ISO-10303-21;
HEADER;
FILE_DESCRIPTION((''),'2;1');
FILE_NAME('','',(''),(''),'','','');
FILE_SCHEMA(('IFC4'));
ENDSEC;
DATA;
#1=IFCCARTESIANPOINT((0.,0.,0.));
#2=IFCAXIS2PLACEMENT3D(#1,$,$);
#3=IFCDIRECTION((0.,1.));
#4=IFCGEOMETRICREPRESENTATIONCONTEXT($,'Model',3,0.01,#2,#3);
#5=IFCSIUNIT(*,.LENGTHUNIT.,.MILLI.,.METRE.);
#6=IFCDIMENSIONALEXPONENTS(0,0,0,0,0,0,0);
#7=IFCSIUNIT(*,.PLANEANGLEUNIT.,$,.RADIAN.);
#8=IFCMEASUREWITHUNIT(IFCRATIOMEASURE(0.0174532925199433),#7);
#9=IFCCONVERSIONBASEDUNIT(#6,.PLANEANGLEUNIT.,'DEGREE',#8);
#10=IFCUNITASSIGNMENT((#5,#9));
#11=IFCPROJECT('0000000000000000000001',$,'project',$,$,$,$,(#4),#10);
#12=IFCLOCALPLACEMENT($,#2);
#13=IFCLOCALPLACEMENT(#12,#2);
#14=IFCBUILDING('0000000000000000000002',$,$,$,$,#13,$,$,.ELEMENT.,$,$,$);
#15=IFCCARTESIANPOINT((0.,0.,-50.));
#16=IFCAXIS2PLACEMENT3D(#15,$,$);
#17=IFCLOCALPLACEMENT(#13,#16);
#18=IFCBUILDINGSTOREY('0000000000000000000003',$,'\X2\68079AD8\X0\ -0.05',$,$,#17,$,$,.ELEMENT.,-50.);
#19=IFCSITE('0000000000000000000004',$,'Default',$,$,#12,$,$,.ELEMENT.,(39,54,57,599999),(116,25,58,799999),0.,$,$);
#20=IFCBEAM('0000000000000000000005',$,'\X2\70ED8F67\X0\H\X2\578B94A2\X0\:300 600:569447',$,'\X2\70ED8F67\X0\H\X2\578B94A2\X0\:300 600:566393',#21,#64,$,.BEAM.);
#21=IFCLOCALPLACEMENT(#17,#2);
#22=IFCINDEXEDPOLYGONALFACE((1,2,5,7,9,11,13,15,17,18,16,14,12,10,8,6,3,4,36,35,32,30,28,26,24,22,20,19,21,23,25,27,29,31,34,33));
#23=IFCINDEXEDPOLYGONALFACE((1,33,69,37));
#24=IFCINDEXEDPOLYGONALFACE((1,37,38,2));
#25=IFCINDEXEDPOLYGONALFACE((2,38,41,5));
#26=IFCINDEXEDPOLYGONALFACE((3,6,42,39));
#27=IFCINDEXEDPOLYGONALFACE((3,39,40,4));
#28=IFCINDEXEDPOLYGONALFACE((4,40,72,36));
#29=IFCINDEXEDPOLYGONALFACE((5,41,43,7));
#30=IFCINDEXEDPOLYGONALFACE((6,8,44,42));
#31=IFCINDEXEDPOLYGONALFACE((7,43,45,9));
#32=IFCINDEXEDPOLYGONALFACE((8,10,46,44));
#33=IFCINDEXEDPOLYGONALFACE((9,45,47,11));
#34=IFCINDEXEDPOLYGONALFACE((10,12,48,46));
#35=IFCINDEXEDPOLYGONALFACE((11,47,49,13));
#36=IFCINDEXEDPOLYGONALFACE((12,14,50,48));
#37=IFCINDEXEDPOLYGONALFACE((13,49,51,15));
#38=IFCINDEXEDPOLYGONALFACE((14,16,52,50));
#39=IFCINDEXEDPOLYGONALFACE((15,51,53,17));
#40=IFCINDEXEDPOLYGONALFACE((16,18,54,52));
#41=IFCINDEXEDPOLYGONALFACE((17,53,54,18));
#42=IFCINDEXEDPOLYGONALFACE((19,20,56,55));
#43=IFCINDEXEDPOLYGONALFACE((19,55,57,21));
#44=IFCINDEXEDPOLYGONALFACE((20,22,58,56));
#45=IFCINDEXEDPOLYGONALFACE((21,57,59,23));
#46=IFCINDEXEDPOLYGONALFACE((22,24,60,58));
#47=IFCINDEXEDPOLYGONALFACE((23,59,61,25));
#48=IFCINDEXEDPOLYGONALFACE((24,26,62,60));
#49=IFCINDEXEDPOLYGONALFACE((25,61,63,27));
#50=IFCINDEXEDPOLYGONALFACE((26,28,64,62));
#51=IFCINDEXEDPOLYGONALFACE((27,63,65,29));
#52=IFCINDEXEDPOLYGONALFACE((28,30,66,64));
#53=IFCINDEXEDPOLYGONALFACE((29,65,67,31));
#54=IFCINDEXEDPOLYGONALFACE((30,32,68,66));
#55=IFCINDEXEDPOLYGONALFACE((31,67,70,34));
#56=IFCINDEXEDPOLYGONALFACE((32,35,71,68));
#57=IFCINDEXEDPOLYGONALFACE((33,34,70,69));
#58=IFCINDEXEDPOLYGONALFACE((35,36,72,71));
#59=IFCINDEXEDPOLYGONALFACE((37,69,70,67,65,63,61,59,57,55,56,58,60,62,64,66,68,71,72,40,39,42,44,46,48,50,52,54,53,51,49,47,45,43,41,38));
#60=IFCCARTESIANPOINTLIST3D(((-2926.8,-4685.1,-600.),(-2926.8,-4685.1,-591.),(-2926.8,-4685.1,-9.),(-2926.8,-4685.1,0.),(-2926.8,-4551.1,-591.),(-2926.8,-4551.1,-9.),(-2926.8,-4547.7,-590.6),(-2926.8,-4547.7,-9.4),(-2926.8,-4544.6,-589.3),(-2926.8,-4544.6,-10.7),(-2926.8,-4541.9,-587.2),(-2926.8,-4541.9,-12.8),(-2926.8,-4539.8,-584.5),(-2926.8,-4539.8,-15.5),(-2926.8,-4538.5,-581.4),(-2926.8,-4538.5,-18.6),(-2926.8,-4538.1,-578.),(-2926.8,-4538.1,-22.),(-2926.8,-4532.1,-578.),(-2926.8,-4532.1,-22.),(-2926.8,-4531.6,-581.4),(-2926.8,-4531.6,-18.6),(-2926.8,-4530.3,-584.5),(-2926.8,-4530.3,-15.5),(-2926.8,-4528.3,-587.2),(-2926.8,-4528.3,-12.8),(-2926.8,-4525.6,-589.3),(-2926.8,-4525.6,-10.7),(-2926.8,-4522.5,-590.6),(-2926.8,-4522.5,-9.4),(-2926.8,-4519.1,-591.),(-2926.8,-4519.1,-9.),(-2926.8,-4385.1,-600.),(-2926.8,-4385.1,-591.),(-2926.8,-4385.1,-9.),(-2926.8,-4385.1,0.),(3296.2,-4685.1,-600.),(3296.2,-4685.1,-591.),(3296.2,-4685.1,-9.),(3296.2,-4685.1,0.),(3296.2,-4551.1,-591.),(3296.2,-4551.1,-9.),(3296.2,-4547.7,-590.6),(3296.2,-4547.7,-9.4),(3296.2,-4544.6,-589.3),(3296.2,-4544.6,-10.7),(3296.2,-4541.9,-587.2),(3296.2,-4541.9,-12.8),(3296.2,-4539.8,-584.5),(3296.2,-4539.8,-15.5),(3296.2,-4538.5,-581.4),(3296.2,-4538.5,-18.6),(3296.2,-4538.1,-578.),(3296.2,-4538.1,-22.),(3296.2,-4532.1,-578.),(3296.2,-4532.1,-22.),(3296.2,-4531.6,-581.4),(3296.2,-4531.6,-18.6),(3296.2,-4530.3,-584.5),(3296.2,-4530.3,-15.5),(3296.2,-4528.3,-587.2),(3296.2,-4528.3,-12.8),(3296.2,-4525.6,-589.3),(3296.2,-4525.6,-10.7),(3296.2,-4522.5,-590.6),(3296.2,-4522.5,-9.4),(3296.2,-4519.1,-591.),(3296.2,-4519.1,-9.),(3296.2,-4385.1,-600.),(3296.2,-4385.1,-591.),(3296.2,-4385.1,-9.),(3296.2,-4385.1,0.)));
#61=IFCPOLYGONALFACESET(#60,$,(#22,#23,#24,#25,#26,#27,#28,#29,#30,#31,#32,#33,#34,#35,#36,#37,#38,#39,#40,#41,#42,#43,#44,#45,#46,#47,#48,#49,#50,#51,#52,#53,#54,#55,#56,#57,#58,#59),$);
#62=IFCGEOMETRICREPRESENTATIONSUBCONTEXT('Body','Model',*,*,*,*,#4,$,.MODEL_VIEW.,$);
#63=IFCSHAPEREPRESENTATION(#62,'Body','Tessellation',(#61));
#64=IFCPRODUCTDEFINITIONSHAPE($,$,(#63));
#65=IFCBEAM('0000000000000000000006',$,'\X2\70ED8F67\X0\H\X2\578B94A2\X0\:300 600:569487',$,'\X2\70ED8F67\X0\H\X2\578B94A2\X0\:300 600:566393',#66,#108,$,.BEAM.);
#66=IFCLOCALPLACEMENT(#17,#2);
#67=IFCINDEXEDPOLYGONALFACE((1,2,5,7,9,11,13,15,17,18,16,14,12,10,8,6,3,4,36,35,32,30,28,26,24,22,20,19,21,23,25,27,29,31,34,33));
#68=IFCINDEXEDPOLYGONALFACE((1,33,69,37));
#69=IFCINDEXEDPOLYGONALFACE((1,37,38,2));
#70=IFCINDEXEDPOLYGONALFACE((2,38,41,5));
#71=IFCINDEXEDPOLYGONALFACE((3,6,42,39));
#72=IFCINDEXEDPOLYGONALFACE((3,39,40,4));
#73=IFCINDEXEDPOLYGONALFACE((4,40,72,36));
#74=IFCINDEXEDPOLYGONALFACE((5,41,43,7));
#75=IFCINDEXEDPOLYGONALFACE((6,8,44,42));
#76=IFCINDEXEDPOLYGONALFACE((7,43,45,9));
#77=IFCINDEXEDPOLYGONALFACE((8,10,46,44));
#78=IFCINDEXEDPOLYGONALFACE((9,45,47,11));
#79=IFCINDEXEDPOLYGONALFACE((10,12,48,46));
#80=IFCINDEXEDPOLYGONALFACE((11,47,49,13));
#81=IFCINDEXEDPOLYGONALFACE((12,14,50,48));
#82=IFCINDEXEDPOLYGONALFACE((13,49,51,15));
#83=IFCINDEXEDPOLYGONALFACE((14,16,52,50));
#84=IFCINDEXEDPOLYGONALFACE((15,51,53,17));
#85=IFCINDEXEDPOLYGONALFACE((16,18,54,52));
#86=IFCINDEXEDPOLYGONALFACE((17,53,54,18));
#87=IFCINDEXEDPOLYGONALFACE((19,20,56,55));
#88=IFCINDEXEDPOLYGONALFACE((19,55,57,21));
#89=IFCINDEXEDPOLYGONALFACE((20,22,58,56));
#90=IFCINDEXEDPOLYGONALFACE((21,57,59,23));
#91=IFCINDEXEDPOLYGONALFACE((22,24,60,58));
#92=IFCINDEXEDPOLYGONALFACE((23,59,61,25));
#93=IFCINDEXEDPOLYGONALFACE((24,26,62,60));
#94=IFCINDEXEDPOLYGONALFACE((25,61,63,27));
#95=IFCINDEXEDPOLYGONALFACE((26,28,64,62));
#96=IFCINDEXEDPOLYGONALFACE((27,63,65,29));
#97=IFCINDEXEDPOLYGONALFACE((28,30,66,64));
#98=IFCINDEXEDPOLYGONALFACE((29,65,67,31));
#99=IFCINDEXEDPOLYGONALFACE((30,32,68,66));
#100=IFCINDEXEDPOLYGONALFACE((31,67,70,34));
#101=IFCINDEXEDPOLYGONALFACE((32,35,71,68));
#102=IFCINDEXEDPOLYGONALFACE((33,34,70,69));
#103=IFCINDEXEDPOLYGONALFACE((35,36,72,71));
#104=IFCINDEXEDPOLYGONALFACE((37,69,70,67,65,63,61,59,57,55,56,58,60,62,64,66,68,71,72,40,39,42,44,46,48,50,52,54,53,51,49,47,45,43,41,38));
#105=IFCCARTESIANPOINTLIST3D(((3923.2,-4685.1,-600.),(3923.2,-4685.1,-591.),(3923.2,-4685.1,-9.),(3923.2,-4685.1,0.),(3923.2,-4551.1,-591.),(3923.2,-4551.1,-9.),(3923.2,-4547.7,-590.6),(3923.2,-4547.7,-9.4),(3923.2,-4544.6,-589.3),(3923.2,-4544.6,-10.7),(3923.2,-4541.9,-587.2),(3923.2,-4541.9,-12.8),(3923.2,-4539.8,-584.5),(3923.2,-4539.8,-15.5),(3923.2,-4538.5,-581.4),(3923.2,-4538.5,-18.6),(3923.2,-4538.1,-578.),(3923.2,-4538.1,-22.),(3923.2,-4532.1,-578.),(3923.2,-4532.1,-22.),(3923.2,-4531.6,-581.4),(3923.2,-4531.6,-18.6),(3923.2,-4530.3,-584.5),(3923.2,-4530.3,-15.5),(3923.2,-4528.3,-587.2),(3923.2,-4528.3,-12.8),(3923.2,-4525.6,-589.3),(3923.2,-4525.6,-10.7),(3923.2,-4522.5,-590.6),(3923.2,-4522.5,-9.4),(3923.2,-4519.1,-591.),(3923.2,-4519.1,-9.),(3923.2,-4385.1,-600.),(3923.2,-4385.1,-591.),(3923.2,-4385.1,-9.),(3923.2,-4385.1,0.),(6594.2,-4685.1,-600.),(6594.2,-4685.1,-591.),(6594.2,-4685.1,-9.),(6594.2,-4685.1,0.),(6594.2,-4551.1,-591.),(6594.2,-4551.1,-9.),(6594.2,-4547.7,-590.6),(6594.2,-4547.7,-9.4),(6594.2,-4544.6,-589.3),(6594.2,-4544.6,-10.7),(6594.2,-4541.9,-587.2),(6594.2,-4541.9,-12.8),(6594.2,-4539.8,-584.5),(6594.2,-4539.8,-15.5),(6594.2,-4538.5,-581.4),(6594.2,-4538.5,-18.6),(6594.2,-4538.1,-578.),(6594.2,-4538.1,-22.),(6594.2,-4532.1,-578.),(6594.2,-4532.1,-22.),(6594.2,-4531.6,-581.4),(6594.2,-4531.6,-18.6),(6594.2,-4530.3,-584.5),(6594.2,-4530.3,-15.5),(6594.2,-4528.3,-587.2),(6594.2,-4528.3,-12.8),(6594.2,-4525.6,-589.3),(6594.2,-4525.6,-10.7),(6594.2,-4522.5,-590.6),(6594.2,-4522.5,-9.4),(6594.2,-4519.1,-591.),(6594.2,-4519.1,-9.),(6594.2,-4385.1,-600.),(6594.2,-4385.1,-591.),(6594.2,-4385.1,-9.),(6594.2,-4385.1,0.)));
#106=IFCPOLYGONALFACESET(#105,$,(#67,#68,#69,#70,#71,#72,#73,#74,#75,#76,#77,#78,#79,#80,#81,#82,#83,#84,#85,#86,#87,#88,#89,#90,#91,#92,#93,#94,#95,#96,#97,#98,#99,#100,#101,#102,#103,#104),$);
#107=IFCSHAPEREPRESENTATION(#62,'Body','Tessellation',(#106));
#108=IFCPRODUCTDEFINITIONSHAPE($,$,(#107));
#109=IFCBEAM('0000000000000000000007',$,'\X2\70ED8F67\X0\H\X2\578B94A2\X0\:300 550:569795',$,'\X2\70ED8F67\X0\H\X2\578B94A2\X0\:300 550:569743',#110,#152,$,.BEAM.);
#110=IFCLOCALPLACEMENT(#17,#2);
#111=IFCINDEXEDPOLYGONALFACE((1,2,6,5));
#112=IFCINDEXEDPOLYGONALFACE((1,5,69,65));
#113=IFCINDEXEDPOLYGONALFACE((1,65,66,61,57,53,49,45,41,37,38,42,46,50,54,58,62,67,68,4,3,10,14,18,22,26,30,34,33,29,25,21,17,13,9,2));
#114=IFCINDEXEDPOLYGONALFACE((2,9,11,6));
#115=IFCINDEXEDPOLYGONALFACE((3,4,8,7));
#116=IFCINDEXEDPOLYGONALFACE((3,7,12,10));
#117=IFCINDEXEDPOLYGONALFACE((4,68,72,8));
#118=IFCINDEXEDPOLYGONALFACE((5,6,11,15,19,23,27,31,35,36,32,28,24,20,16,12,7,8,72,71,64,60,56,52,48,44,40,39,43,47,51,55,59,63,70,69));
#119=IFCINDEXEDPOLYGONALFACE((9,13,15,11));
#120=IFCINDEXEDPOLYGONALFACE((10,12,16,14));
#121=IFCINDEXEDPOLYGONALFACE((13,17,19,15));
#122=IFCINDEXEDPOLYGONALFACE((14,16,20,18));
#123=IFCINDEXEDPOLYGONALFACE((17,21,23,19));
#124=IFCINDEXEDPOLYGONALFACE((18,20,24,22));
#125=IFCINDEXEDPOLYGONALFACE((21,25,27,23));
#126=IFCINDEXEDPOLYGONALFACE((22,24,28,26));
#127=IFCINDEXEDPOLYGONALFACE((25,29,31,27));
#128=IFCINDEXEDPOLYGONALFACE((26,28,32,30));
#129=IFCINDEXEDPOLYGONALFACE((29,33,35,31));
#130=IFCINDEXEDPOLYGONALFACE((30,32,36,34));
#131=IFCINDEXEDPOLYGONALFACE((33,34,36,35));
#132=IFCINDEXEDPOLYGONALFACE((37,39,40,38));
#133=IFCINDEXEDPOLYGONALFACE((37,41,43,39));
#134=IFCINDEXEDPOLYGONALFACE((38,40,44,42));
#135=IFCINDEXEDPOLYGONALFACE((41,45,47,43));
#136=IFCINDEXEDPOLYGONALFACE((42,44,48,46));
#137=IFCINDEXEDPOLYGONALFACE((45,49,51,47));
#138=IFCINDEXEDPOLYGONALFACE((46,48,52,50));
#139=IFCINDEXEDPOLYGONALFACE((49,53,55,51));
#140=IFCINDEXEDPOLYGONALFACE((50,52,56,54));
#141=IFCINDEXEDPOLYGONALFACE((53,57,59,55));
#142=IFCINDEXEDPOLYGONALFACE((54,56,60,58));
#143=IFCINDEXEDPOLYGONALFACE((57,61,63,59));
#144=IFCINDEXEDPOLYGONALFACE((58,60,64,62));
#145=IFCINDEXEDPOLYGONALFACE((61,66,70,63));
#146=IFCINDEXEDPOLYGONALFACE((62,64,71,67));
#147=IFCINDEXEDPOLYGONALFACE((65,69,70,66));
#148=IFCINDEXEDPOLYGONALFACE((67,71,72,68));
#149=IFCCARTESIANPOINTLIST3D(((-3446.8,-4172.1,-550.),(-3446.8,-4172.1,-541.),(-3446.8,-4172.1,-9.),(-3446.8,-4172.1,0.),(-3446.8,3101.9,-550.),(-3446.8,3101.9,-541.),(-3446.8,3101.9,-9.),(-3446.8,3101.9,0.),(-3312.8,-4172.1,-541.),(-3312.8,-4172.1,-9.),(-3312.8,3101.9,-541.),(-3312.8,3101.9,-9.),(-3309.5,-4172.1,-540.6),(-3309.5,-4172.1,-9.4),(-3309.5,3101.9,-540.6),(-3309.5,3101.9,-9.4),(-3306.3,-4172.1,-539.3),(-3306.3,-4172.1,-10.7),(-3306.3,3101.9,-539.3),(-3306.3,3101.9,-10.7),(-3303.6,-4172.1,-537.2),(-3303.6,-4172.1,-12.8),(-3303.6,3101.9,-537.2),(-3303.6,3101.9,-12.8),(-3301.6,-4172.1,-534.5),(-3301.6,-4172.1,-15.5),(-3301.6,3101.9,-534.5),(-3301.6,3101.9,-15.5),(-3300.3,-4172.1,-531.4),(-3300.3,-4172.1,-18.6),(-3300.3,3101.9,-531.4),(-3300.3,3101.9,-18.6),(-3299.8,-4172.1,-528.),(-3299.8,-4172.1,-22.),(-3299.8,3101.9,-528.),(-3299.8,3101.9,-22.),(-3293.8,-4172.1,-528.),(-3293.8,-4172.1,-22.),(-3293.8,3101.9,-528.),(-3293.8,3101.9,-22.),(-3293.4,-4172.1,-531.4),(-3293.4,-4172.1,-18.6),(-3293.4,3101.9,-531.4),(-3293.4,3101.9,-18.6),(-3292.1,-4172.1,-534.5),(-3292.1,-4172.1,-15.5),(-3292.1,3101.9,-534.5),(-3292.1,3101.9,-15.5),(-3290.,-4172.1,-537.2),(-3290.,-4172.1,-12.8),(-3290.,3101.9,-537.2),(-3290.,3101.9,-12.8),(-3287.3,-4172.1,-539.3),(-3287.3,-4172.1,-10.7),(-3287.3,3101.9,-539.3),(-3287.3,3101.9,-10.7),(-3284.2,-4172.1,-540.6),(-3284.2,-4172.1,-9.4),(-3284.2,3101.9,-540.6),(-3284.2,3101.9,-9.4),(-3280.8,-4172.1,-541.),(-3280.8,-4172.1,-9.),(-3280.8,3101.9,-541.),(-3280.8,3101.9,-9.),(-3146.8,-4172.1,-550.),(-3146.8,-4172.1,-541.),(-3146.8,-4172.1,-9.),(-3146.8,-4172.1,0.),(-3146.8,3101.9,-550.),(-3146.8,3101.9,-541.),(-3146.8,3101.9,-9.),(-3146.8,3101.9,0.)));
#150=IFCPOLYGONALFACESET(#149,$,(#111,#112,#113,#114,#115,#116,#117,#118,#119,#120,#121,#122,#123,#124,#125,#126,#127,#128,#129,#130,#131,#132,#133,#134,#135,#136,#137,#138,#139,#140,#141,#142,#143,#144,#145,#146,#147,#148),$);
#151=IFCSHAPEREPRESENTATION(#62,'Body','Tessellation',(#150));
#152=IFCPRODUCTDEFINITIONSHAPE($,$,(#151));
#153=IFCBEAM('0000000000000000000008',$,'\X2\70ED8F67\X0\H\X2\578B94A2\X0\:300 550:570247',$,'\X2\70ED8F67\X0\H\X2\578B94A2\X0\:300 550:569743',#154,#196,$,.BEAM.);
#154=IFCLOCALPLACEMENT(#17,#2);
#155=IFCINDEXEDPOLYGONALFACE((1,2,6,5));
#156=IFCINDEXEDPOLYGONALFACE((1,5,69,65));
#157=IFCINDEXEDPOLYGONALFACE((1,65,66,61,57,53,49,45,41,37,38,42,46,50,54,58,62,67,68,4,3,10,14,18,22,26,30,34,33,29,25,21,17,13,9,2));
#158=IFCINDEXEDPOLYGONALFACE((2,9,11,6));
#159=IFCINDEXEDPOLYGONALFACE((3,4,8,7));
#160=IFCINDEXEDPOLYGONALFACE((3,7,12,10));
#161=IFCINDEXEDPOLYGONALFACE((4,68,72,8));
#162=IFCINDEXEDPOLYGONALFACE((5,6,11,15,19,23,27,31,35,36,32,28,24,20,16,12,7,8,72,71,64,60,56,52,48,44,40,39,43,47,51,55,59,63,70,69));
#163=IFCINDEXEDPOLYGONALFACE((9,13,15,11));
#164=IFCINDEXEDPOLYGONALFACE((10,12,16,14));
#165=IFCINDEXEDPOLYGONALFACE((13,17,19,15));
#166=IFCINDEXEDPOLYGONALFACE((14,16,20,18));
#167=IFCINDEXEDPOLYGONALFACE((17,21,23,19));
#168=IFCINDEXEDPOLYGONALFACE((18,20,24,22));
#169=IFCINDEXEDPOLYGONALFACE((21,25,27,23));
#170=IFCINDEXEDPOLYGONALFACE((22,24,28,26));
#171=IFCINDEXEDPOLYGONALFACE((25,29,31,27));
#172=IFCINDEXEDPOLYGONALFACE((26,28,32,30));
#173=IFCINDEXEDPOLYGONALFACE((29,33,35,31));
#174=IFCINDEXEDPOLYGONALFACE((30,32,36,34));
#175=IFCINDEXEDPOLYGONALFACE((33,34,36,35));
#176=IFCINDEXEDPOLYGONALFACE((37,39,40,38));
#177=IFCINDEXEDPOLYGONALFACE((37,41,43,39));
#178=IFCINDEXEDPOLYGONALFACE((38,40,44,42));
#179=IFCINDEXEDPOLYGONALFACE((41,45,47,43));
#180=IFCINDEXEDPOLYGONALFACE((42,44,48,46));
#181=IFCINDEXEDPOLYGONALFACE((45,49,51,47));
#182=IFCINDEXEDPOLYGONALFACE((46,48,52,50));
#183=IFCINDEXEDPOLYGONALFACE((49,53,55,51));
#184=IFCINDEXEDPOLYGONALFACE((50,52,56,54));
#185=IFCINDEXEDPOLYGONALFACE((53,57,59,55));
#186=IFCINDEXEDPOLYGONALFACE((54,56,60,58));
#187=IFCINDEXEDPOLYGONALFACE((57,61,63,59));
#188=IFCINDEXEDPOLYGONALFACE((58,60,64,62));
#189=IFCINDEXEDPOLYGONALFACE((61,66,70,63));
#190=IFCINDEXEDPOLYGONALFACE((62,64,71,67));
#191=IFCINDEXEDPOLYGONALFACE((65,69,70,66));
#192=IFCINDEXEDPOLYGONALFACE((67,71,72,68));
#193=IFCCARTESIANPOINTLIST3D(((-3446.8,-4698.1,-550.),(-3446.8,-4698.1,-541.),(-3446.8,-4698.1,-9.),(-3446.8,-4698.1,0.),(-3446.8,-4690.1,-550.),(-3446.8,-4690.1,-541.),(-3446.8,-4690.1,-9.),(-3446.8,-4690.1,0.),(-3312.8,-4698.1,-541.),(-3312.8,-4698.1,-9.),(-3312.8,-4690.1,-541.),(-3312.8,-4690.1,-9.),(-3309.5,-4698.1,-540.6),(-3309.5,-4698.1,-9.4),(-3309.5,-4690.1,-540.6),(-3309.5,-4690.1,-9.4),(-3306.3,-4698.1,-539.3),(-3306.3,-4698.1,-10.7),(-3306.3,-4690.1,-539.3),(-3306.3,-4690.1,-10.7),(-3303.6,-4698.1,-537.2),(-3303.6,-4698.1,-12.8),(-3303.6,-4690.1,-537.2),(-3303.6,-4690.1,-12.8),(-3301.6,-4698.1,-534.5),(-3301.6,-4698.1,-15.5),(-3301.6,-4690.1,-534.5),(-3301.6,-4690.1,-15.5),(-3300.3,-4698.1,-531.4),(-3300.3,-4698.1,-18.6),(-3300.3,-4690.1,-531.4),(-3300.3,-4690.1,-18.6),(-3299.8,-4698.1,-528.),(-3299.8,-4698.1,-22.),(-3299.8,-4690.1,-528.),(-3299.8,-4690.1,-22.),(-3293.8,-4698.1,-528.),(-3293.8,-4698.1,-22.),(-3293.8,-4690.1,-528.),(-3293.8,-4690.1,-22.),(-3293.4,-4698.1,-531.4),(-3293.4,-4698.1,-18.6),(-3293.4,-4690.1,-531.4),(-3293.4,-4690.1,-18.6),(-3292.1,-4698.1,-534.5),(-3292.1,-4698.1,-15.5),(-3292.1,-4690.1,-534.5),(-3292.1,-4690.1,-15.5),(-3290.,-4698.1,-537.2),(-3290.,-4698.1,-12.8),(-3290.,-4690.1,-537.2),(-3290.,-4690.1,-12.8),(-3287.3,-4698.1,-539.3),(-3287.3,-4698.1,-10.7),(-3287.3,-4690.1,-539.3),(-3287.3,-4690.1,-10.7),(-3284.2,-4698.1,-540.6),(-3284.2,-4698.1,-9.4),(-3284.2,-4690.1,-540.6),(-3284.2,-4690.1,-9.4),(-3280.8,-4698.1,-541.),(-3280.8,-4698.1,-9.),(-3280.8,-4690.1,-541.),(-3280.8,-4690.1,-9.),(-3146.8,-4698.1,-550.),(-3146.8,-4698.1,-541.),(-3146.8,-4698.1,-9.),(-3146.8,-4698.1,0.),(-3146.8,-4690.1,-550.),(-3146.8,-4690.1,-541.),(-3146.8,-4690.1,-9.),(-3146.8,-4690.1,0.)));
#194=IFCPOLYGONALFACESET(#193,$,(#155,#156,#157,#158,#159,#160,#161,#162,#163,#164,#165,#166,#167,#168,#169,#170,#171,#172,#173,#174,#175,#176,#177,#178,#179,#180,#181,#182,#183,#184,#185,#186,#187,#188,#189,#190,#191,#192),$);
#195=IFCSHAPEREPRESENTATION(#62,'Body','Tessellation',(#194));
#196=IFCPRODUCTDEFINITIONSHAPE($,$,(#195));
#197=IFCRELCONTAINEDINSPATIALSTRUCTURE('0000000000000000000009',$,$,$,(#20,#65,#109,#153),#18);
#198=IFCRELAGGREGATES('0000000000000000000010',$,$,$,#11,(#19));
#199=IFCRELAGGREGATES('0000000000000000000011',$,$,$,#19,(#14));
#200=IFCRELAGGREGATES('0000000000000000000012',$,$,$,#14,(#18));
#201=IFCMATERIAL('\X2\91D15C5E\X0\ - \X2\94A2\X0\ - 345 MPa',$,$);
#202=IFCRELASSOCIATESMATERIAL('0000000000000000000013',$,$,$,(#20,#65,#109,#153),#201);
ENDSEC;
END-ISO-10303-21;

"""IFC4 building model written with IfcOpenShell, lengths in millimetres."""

from ifc_helpers import new_model, entity, si_unit, converted_unit, direction, frame, frame_2d, origin, place, context, subcontext, project, spatial, i_section, extrude, material, element, save


model = new_model("IFC4")

# Units and contexts
model_context = context("Model", 3, precision=0.01, world=origin(), true_north=direction((0.0, 1.0)))
body_context = subcontext(model_context, "Body", "Model", "MODEL_VIEW")
ifc_project = project(units=[si_unit("LENGTHUNIT", "METRE", prefix="MILLI"), converted_unit("PLANEANGLEUNIT", "DEGREE", entity("IfcRatioMeasure", 0.0174532925199433), si_unit("PLANEANGLEUNIT", "RADIAN"), dimensions=[0, 0, 0, 0, 0, 0, 0])], contexts=[model_context])

# Site, building, storey
site_placement = place(None, origin())
site = spatial("IfcSite", under=ifc_project, at=site_placement, Name="Default", CompositionType="ELEMENT", RefLatitude=(39, 54, 57, 599999), RefLongitude=(116, 25, 58, 799999), RefElevation=0.0)
building_placement = place(site_placement, origin())
building = spatial("IfcBuilding", under=site, at=building_placement, CompositionType="ELEMENT")
storey_placement = place(building_placement, frame((0.0, 0.0, -50.0)))
storey = spatial("IfcBuildingStorey", under=building, at=storey_placement, Name="标高 -0.05", CompositionType="ELEMENT", Elevation=-50.0)

# Beams
ifc_material_1 = material(Name="金属 - 钢 - 345 MPa")
beam_1_placement = place(storey_placement, frame((-2946.8, -4535.1, 0.0)))
element("IfcBeam", 1, at=beam_1_placement, inside=storey, material=ifc_material_1, Name="热轧H型钢:300 600:569447", ObjectType="热轧H型钢:300 600:566393", PredefinedType="BEAM", context=body_context, shape_type="SweptSolid", body=[
    extrude(i_section(OverallWidth=300.0, OverallDepth=600.0, WebThickness=6.0, FlangeThickness=9.0, FilletRadius=13.0, at=frame_2d((0.0, 0.0), x_axis=(0.0, 1.0))), frame((20.0, 0.0, -300.0), z_axis=(1.0, 0.0, 0.0), x_axis=(0.0, 0.0, -1.0)), (0.0, 0.0, 1.0), 6223.0),
])
beam_2_placement = place(storey_placement, frame((3903.2, -4535.1, 0.0)))
element("IfcBeam", 2, at=beam_2_placement, inside=storey, material=ifc_material_1, Name="热轧H型钢:300 600:569487", ObjectType="热轧H型钢:300 600:566393", PredefinedType="BEAM", context=body_context, shape_type="SweptSolid", body=[
    extrude(i_section(OverallWidth=300.0, OverallDepth=600.0, WebThickness=6.0, FlangeThickness=9.0, FilletRadius=13.0, at=frame_2d((0.0, 0.0), x_axis=(0.0, 1.0))), frame((20.0, 0.0, -300.0), z_axis=(1.0, 0.0, 0.0), x_axis=(0.0, 0.0, -1.0)), (0.0, 0.0, 1.0), 2671.0),
])
beam_3_placement = place(storey_placement, frame((-3296.8, -4190.1, 0.0), z_axis=(0.0, 0.0, 1.0), x_axis=(0.0, 1.0, 0.0)))
element("IfcBeam", 3, at=beam_3_placement, inside=storey, material=ifc_material_1, Name="热轧H型钢:300 550:569795", ObjectType="热轧H型钢:300 550:569743", PredefinedType="BEAM", context=body_context, shape_type="SweptSolid", body=[
    extrude(i_section(OverallWidth=300.0, OverallDepth=550.0, WebThickness=6.0, FlangeThickness=9.0, FilletRadius=13.0, at=frame_2d((0.0, 0.0), x_axis=(0.0, 1.0))), frame((18.0, 0.0, -275.0), z_axis=(1.0, 0.0, 0.0), x_axis=(0.0, 0.0, -1.0)), (0.0, 0.0, 1.0), 7274.0),
])
beam_4_placement = place(storey_placement, frame((-3296.8, -4190.1, 0.0), z_axis=(0.0, 0.0, 1.0), x_axis=(0.0, -1.0, 0.0)))
element("IfcBeam", 4, at=beam_4_placement, inside=storey, material=ifc_material_1, Name="热轧H型钢:300 550:570247", ObjectType="热轧H型钢:300 550:569743", PredefinedType="BEAM", context=body_context, shape_type="SweptSolid", body=[
    extrude(i_section(OverallWidth=300.0, OverallDepth=550.0, WebThickness=6.0, FlangeThickness=9.0, FilletRadius=13.0, at=frame_2d((0.0, 0.0), x_axis=(0.0, 1.0))), frame((500.0, 0.0, -275.0), z_axis=(1.0, 0.0, 0.0), x_axis=(0.0, 0.0, -1.0)), (0.0, 0.0, 1.0), 8.0),
])

save(model, "model.ifc")
